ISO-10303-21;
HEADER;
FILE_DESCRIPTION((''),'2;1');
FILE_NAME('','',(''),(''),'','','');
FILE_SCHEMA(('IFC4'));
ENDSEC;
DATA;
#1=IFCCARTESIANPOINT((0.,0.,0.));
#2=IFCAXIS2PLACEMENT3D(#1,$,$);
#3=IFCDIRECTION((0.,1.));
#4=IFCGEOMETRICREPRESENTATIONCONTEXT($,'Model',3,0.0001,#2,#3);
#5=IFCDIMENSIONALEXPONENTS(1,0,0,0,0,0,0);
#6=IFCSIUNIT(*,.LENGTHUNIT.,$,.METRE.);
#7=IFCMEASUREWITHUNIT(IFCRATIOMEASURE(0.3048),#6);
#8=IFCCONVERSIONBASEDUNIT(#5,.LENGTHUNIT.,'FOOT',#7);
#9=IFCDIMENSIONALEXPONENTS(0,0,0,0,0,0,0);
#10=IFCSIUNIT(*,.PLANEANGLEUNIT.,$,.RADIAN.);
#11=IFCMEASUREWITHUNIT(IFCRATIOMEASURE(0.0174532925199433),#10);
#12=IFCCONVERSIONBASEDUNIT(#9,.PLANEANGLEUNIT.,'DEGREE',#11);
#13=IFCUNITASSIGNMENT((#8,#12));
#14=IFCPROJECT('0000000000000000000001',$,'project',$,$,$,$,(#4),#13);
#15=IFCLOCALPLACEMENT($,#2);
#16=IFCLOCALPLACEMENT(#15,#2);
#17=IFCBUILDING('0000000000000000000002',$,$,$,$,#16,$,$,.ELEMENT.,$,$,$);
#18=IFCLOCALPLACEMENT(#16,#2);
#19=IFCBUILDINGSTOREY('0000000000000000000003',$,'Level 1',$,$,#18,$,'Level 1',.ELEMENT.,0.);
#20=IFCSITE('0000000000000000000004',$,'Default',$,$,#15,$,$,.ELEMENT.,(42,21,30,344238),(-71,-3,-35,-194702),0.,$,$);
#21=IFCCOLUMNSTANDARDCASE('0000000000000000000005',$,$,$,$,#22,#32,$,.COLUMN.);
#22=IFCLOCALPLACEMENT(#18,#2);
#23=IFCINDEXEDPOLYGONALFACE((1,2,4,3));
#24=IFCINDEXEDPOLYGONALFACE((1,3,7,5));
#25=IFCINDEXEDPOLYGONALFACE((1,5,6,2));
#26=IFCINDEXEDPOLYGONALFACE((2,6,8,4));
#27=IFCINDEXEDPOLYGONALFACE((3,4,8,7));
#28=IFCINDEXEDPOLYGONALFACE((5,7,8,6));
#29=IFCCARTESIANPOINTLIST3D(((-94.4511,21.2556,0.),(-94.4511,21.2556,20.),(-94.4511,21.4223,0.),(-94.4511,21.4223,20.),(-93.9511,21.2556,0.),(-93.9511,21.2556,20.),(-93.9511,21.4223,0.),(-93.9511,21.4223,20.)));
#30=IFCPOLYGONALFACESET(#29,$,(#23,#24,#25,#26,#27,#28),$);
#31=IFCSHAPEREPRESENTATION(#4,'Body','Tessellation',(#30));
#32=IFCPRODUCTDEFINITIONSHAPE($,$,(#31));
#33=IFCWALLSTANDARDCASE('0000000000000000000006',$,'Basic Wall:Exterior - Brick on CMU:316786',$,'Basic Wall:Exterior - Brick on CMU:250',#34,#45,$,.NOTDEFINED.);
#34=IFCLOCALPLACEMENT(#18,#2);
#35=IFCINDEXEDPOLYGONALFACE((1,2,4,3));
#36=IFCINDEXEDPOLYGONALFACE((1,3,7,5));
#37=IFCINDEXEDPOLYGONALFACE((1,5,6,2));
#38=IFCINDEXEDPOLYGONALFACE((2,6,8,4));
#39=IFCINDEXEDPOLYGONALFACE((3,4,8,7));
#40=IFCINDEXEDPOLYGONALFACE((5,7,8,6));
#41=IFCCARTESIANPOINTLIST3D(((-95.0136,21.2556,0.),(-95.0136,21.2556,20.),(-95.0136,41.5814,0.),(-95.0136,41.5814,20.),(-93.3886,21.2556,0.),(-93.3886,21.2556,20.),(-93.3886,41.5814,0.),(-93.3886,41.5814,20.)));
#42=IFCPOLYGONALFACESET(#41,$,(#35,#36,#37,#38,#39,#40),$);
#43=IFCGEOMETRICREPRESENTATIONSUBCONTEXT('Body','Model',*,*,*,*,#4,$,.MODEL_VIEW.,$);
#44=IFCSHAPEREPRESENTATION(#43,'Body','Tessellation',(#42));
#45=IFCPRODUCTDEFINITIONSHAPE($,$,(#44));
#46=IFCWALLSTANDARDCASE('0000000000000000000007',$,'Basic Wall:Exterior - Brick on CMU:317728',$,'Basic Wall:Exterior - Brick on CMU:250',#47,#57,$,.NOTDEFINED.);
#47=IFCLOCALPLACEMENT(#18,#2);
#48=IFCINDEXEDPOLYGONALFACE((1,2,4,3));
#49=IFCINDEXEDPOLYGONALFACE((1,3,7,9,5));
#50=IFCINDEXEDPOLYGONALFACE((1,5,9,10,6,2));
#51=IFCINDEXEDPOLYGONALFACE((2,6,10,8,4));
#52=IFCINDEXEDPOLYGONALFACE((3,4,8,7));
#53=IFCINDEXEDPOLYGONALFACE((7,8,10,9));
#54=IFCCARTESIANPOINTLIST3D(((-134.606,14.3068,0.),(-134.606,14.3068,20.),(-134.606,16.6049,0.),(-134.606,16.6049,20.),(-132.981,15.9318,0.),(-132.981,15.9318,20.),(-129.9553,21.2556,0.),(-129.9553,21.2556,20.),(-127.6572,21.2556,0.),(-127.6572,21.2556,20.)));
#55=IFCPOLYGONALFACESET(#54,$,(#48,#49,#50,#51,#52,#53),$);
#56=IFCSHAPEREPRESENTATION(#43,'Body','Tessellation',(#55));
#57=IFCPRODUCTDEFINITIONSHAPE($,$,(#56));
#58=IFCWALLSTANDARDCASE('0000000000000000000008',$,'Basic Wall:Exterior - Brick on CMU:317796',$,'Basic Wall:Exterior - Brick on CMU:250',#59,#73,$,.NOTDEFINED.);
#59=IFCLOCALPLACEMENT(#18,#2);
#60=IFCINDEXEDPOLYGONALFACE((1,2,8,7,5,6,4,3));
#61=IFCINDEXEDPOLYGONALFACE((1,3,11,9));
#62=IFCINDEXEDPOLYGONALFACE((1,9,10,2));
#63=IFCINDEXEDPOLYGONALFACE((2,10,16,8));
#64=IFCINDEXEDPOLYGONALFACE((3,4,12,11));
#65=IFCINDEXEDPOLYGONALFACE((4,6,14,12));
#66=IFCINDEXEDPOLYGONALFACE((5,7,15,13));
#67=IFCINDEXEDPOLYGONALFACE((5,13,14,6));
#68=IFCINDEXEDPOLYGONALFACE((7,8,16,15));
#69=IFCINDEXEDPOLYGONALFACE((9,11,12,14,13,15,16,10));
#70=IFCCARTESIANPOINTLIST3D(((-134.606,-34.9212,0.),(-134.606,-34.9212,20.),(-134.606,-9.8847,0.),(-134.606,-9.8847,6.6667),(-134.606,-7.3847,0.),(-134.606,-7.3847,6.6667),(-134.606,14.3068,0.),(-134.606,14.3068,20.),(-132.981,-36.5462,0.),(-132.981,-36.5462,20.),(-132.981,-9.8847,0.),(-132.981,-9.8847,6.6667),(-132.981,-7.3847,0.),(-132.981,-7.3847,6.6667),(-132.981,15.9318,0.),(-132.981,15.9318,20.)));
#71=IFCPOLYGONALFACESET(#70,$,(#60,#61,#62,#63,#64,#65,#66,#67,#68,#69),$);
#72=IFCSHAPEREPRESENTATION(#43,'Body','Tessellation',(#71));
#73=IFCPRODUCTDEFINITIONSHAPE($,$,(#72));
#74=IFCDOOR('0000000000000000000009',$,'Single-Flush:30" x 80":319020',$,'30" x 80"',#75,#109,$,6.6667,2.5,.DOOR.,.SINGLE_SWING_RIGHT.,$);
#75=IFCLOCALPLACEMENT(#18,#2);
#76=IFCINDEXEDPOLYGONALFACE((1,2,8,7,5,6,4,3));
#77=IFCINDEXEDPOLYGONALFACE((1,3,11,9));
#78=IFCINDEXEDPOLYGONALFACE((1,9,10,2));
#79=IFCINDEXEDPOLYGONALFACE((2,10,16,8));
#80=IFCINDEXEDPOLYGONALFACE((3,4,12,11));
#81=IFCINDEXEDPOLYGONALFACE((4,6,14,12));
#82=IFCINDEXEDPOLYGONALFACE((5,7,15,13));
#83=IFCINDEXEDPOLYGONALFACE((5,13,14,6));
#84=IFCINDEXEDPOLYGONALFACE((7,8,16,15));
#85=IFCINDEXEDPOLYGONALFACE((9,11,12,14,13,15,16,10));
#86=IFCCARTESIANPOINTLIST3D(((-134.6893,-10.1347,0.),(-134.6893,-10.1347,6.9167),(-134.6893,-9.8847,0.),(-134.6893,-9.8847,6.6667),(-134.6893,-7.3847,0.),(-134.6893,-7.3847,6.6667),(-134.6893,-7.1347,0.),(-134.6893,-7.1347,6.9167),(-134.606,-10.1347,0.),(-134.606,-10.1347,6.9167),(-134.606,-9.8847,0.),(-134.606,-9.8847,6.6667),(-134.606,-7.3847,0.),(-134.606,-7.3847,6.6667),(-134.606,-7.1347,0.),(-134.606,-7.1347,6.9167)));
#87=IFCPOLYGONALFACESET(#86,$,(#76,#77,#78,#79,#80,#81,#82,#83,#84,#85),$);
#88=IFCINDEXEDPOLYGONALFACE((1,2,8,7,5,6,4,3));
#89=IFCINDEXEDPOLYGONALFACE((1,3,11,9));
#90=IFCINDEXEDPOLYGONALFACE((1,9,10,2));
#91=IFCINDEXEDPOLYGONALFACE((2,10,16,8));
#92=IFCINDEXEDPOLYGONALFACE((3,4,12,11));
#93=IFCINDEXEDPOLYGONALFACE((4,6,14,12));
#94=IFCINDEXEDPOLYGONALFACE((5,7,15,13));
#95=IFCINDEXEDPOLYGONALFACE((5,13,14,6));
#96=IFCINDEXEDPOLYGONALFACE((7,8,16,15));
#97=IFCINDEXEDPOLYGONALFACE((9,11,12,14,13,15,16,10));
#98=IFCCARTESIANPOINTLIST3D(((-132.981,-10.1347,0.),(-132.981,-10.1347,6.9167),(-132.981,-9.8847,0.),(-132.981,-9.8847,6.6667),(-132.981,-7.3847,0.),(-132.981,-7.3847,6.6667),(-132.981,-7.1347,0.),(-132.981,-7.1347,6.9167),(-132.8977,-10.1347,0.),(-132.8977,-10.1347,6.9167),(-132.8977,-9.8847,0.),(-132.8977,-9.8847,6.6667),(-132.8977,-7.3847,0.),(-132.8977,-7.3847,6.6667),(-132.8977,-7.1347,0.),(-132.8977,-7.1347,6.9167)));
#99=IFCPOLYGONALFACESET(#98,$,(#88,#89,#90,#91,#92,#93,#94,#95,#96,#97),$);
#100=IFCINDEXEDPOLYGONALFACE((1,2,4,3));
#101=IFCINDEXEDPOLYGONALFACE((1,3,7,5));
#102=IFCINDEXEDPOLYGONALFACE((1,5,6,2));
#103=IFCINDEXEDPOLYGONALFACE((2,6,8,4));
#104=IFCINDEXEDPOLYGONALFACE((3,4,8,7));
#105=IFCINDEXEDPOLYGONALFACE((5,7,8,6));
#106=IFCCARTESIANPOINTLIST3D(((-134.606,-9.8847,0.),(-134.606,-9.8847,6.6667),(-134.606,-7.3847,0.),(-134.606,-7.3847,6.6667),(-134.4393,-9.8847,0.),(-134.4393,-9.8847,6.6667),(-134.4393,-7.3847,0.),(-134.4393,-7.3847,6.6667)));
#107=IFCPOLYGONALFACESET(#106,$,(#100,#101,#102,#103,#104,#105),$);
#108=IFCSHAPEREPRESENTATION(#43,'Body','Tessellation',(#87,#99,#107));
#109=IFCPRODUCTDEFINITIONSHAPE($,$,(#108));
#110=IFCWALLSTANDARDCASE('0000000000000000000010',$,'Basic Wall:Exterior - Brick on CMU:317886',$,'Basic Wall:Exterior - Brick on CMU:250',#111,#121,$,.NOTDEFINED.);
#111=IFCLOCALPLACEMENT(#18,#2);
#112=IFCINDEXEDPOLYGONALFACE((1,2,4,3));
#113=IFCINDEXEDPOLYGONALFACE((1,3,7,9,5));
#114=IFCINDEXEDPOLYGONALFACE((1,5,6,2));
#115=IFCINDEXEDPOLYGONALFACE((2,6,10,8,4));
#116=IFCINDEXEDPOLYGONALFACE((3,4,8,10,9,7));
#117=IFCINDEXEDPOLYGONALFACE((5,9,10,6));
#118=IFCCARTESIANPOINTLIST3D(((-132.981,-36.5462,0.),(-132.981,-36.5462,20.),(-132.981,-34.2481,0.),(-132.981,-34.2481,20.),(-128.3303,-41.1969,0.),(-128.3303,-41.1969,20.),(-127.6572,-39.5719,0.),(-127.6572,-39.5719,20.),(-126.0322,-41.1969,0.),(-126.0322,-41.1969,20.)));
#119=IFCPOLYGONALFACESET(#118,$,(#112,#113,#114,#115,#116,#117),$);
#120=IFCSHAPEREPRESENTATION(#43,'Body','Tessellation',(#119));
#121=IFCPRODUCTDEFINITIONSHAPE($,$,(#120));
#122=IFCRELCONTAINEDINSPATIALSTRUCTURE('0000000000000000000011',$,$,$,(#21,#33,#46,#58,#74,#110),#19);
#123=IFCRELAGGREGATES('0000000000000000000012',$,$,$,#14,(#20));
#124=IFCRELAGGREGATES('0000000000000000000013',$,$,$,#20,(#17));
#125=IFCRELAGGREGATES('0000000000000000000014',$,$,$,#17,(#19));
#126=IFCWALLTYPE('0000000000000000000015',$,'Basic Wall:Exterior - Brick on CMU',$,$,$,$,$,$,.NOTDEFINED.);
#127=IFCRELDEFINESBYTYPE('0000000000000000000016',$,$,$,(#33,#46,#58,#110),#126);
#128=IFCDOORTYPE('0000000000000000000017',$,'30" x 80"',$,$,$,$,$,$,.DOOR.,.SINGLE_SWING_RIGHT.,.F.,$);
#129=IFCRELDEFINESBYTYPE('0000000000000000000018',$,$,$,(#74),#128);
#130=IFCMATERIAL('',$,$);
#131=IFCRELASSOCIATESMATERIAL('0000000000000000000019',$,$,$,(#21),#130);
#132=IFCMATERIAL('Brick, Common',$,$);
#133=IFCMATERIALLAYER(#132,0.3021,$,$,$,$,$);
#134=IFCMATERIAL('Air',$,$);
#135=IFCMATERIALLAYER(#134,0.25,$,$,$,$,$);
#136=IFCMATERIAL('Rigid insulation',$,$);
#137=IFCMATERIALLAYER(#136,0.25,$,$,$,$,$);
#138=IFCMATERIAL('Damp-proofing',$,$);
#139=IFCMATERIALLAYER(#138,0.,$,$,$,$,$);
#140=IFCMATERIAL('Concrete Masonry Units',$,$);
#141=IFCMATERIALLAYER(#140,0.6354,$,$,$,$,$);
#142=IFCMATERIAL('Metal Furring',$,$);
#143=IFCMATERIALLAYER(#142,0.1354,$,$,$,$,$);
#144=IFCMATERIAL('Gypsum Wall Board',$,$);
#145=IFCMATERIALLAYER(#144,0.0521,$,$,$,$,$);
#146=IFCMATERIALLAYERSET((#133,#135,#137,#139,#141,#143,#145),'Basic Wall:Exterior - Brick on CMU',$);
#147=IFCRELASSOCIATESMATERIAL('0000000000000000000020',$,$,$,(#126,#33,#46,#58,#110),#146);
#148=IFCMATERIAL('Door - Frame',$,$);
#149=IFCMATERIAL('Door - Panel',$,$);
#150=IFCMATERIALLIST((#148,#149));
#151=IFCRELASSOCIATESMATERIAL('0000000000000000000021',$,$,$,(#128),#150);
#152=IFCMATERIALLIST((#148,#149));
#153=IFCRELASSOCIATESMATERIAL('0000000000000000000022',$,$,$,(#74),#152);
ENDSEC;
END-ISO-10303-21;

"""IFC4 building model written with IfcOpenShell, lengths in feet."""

from ifc_helpers import new_model, entity, si_unit, converted_unit, direction, frame, frame_2d, origin, place, context, subcontext, project, spatial, polyline, rectangle, outline, extrude, source, transform, mapped, material, material_list, layer, layer_set, layer_usage, type_object, type_shapes, element, fill, save


model = new_model("IFC4")

# Units and contexts
model_context = context("Model", 3, precision=0.0001, world=origin(), true_north=direction((0.0, 1.0)))
body_context = subcontext(model_context, "Body", "Model", "MODEL_VIEW")
ifc_project = project(units=[converted_unit("LENGTHUNIT", "FOOT", entity("IfcRatioMeasure", 0.3048), si_unit("LENGTHUNIT", "METRE"), dimensions=[1, 0, 0, 0, 0, 0, 0]), converted_unit("PLANEANGLEUNIT", "DEGREE", entity("IfcRatioMeasure", 0.0174532925199433), si_unit("PLANEANGLEUNIT", "RADIAN"), dimensions=[0, 0, 0, 0, 0, 0, 0])], contexts=[model_context])

# Site, building, storey
site_placement = place(None, origin())
site = spatial("IfcSite", under=ifc_project, at=site_placement, Name="Default", CompositionType="ELEMENT", RefLatitude=(42, 21, 30, 344238), RefLongitude=(-71, -3, -35, -194702), RefElevation=0.0)
building_placement = place(site_placement, origin())
building = spatial("IfcBuilding", under=site, at=building_placement, CompositionType="ELEMENT")
storey_placement = place(building_placement, origin())
storey = spatial("IfcBuildingStorey", under=building, at=storey_placement, Name="Level 1", LongName="Level 1", CompositionType="ELEMENT", Elevation=0.0)

# Column
ifc_material_1 = material(Name="")
wall_1_placement = place(storey_placement, frame((-94.2011, 21.2556, 0.0), z_axis=(0.0, 0.0, 1.0), x_axis=(0.0, 1.0, 0.0)))
for number, where, z_axis, x_axis in (
    (1, (0.0833, 0.0, 0.0), (0.0, 0.0, 1.0), (1.0, 0.0, 0.0)),
):
    element("IfcColumnStandardCase", number, at=place(wall_1_placement, frame(where, z_axis=z_axis, x_axis=x_axis)), inside=storey, material=ifc_material_1, PredefinedType="COLUMN", context=model_context, shape_type="SweptSolid", body=[
        extrude(rectangle(XDim=0.1667, YDim=0.5), origin(), (0.0, 0.0, 1.0), 20.0),
    ])

# Walls
ifc_material_2 = material(Name="Brick, Common")
ifc_layer_1 = layer(ifc_material_2, 0.3021)
ifc_material_3 = material(Name="Air")
ifc_layer_2 = layer(ifc_material_3, 0.25)
ifc_material_4 = material(Name="Rigid insulation")
ifc_layer_3 = layer(ifc_material_4, 0.25)
ifc_material_5 = material(Name="Damp-proofing")
ifc_layer_4 = layer(ifc_material_5, 0.0)
ifc_material_6 = material(Name="Concrete Masonry Units")
ifc_layer_5 = layer(ifc_material_6, 0.6354)
ifc_material_7 = material(Name="Metal Furring")
ifc_layer_6 = layer(ifc_material_7, 0.1354)
ifc_material_8 = material(Name="Gypsum Wall Board")
ifc_layer_7 = layer(ifc_material_8, 0.0521)
ifc_layer_set = layer_set([ifc_layer_1, ifc_layer_2, ifc_layer_3, ifc_layer_4, ifc_layer_5, ifc_layer_6, ifc_layer_7], Name="Basic Wall:Exterior - Brick on CMU")
ifc_layer_usage_1 = layer_usage(ifc_layer_set, "AXIS2", "NEGATIVE", 0.8125)
wall_type = type_object("IfcWallType", Name="Basic Wall:Exterior - Brick on CMU", PredefinedType="NOTDEFINED", material=ifc_layer_set)
element("IfcWallStandardCase", 2, at=wall_1_placement, inside=storey, type_object=wall_type, material=ifc_layer_usage_1, Name="Basic Wall:Exterior - Brick on CMU:316786", ObjectType="Basic Wall:Exterior - Brick on CMU:250", PredefinedType="NOTDEFINED", context=body_context, shape_type="SweptSolid", body=[
    extrude(rectangle(XDim=20.3258, YDim=1.625, at=frame_2d((10.1629, 0.0), x_axis=(-1.0, 0.0))), origin(), (0.0, 0.0, 1.0), 20.0),
])
ifc_layer_usage_2 = layer_usage(ifc_layer_set, "AXIS2", "NEGATIVE", 0.8125)
wall_2_placement = place(storey_placement, frame((-128.2317, 21.8302, 0.0), z_axis=(0.0, 0.0, 1.0), x_axis=(-0.707107, -0.707107, 0.0)))
element("IfcWallStandardCase", 3, at=wall_2_placement, inside=storey, type_object=wall_type, material=ifc_layer_usage_2, Name="Basic Wall:Exterior - Brick on CMU:317728", ObjectType="Basic Wall:Exterior - Brick on CMU:250", PredefinedType="NOTDEFINED", context=body_context, shape_type="SweptSolid", body=[
    extrude(outline(polyline([(8.2021, -0.8125), (9.8271, 0.8125), (7.529, 0.8125), (0.0, 0.8125), (1.625, -0.8125), (8.2021, -0.8125)])), origin(), (0.0, 0.0, 1.0), 20.0),
])

# Wall, opening, door
ifc_layer_usage_3 = layer_usage(ifc_layer_set, "AXIS2", "NEGATIVE", 0.8125)
wall_3_placement = place(storey_placement, frame((-133.7935, 15.9318, 0.0), z_axis=(0.0, 0.0, 1.0), x_axis=(0.0, -1.0, 0.0)))
wall_3 = element("IfcWallStandardCase", 4, at=wall_3_placement, inside=storey, type_object=wall_type, material=ifc_layer_usage_3, Name="Basic Wall:Exterior - Brick on CMU:317796", ObjectType="Basic Wall:Exterior - Brick on CMU:250", PredefinedType="NOTDEFINED", context=body_context, shape_type="SweptSolid", body=[
    extrude(outline(polyline([(1.625, -0.8125), (50.853, -0.8125), (52.478, 0.8125), (50.1799, 0.8125), (0.0, 0.8125), (1.625, -0.8125)])), origin(), (0.0, 0.0, 1.0), 20.0),
])
opening_1_placement = place(wall_3_placement, frame((25.8165, 0.8125, 0.0)))
opening_1 = element("IfcOpeningElement", 5, at=opening_1_placement, cuts=wall_3, ObjectType="Opening", PredefinedType="OPENING", context=body_context, shape_type="SweptSolid", body=[
    extrude(rectangle(XDim=2.5, YDim=6.6667, at=frame_2d((3.3333, 1.25), x_axis=(0.0, 1.0))), frame((0.0, 0.0, 0.0), z_axis=(0.0, -1.0, 0.0), x_axis=(0.0, 0.0, 1.0)), (0.0, 0.0, 1.0), 1.625),
])
ifc_material_9 = material(Name="Door - Frame")
ifc_material_10 = material(Name="Door - Panel")
ifc_material_list_1 = material_list([ifc_material_9, ifc_material_10])
ifc_material_list_2 = material_list([ifc_material_9, ifc_material_10])
door_type = type_object("IfcDoorType", Name="30\" x 80\"", OperationType="SINGLE_SWING_RIGHT", ParameterTakesPrecedence=False, PredefinedType="DOOR", material=ifc_material_list_2)
shared_shape_1 = source(origin(), body_context, "Body", "SweptSolid", [
    extrude(outline(polyline([(-1.5, -3.5208), (1.5, -3.5208), (1.5, 3.3958), (1.25, 3.3958), (1.25, -3.2708), (-1.25, -3.2708), (-1.25, 3.3958), (-1.5, 3.3958), (-1.5, -3.5208)])), frame((1.25, 1.625, 3.3958), z_axis=(0.0, 1.0, 0.0), x_axis=(1.0, 0.0, 0.0)), (0.0, 0.0, 1.0), 0.0833),
    extrude(outline(polyline([(-3.5208, -1.5), (3.3958, -1.5), (3.3958, -1.25), (-3.2708, -1.25), (-3.2708, 1.25), (3.3958, 1.25), (3.3958, 1.5), (-3.5208, 1.5), (-3.5208, -1.5)])), frame((1.25, -0.0833, 3.3958), z_axis=(0.0, 1.0, 0.0), x_axis=(0.0, 0.0, -1.0)), (0.0, 0.0, 1.0), 0.0833),
    extrude(rectangle(XDim=0.1667, YDim=2.5, at=frame_2d((0.0, 0.0), x_axis=(1.0, 0.0))), frame((1.25, 1.5417, 0.0), z_axis=(0.0, 0.0, 1.0), x_axis=(0.0, 1.0, 0.0)), (0.0, 0.0, 1.0), 6.6667),
])
type_shapes(door_type, [shared_shape_1])
door_placement = place(opening_1_placement, frame((0.0, 0.0, 0.0), z_axis=(0.0, 0.0, 1.0), x_axis=(-1.0, 0.0, 0.0)))
door = element("IfcDoor", 6, at=door_placement, inside=storey, type_object=door_type, material=ifc_material_list_1, Name="Single-Flush:30\" x 80\":319020", ObjectType="30\" x 80\"", OperationType="SINGLE_SWING_RIGHT", OverallHeight=6.6667, OverallWidth=2.5, PredefinedType="DOOR", context=body_context, shape_type="MappedRepresentation", body=[
    mapped(shared_shape_1, transform((0.0, 0.0, 0.0), scale=1.0)),
])
fill(opening_1, door)

# Wall
ifc_layer_usage_4 = layer_usage(ifc_layer_set, "AXIS2", "NEGATIVE", 0.8125)
wall_4_placement = place(storey_placement, frame((-133.5555, -34.8226, 0.0), z_axis=(0.0, 0.0, 1.0), x_axis=(0.707107, -0.707107, 0.0)))
element("IfcWallStandardCase", 7, at=wall_4_placement, inside=storey, type_object=wall_type, material=ifc_layer_usage_4, Name="Basic Wall:Exterior - Brick on CMU:317886", ObjectType="Basic Wall:Exterior - Brick on CMU:250", PredefinedType="NOTDEFINED", context=body_context, shape_type="SweptSolid", body=[
    extrude(outline(polyline([(8.2021, -0.8125), (9.8271, 0.8125), (7.529, 0.8125), (0.0, 0.8125), (1.625, -0.8125), (8.2021, -0.8125)])), origin(), (0.0, 0.0, 1.0), 20.0),
])

save(model, "model.ifc")
